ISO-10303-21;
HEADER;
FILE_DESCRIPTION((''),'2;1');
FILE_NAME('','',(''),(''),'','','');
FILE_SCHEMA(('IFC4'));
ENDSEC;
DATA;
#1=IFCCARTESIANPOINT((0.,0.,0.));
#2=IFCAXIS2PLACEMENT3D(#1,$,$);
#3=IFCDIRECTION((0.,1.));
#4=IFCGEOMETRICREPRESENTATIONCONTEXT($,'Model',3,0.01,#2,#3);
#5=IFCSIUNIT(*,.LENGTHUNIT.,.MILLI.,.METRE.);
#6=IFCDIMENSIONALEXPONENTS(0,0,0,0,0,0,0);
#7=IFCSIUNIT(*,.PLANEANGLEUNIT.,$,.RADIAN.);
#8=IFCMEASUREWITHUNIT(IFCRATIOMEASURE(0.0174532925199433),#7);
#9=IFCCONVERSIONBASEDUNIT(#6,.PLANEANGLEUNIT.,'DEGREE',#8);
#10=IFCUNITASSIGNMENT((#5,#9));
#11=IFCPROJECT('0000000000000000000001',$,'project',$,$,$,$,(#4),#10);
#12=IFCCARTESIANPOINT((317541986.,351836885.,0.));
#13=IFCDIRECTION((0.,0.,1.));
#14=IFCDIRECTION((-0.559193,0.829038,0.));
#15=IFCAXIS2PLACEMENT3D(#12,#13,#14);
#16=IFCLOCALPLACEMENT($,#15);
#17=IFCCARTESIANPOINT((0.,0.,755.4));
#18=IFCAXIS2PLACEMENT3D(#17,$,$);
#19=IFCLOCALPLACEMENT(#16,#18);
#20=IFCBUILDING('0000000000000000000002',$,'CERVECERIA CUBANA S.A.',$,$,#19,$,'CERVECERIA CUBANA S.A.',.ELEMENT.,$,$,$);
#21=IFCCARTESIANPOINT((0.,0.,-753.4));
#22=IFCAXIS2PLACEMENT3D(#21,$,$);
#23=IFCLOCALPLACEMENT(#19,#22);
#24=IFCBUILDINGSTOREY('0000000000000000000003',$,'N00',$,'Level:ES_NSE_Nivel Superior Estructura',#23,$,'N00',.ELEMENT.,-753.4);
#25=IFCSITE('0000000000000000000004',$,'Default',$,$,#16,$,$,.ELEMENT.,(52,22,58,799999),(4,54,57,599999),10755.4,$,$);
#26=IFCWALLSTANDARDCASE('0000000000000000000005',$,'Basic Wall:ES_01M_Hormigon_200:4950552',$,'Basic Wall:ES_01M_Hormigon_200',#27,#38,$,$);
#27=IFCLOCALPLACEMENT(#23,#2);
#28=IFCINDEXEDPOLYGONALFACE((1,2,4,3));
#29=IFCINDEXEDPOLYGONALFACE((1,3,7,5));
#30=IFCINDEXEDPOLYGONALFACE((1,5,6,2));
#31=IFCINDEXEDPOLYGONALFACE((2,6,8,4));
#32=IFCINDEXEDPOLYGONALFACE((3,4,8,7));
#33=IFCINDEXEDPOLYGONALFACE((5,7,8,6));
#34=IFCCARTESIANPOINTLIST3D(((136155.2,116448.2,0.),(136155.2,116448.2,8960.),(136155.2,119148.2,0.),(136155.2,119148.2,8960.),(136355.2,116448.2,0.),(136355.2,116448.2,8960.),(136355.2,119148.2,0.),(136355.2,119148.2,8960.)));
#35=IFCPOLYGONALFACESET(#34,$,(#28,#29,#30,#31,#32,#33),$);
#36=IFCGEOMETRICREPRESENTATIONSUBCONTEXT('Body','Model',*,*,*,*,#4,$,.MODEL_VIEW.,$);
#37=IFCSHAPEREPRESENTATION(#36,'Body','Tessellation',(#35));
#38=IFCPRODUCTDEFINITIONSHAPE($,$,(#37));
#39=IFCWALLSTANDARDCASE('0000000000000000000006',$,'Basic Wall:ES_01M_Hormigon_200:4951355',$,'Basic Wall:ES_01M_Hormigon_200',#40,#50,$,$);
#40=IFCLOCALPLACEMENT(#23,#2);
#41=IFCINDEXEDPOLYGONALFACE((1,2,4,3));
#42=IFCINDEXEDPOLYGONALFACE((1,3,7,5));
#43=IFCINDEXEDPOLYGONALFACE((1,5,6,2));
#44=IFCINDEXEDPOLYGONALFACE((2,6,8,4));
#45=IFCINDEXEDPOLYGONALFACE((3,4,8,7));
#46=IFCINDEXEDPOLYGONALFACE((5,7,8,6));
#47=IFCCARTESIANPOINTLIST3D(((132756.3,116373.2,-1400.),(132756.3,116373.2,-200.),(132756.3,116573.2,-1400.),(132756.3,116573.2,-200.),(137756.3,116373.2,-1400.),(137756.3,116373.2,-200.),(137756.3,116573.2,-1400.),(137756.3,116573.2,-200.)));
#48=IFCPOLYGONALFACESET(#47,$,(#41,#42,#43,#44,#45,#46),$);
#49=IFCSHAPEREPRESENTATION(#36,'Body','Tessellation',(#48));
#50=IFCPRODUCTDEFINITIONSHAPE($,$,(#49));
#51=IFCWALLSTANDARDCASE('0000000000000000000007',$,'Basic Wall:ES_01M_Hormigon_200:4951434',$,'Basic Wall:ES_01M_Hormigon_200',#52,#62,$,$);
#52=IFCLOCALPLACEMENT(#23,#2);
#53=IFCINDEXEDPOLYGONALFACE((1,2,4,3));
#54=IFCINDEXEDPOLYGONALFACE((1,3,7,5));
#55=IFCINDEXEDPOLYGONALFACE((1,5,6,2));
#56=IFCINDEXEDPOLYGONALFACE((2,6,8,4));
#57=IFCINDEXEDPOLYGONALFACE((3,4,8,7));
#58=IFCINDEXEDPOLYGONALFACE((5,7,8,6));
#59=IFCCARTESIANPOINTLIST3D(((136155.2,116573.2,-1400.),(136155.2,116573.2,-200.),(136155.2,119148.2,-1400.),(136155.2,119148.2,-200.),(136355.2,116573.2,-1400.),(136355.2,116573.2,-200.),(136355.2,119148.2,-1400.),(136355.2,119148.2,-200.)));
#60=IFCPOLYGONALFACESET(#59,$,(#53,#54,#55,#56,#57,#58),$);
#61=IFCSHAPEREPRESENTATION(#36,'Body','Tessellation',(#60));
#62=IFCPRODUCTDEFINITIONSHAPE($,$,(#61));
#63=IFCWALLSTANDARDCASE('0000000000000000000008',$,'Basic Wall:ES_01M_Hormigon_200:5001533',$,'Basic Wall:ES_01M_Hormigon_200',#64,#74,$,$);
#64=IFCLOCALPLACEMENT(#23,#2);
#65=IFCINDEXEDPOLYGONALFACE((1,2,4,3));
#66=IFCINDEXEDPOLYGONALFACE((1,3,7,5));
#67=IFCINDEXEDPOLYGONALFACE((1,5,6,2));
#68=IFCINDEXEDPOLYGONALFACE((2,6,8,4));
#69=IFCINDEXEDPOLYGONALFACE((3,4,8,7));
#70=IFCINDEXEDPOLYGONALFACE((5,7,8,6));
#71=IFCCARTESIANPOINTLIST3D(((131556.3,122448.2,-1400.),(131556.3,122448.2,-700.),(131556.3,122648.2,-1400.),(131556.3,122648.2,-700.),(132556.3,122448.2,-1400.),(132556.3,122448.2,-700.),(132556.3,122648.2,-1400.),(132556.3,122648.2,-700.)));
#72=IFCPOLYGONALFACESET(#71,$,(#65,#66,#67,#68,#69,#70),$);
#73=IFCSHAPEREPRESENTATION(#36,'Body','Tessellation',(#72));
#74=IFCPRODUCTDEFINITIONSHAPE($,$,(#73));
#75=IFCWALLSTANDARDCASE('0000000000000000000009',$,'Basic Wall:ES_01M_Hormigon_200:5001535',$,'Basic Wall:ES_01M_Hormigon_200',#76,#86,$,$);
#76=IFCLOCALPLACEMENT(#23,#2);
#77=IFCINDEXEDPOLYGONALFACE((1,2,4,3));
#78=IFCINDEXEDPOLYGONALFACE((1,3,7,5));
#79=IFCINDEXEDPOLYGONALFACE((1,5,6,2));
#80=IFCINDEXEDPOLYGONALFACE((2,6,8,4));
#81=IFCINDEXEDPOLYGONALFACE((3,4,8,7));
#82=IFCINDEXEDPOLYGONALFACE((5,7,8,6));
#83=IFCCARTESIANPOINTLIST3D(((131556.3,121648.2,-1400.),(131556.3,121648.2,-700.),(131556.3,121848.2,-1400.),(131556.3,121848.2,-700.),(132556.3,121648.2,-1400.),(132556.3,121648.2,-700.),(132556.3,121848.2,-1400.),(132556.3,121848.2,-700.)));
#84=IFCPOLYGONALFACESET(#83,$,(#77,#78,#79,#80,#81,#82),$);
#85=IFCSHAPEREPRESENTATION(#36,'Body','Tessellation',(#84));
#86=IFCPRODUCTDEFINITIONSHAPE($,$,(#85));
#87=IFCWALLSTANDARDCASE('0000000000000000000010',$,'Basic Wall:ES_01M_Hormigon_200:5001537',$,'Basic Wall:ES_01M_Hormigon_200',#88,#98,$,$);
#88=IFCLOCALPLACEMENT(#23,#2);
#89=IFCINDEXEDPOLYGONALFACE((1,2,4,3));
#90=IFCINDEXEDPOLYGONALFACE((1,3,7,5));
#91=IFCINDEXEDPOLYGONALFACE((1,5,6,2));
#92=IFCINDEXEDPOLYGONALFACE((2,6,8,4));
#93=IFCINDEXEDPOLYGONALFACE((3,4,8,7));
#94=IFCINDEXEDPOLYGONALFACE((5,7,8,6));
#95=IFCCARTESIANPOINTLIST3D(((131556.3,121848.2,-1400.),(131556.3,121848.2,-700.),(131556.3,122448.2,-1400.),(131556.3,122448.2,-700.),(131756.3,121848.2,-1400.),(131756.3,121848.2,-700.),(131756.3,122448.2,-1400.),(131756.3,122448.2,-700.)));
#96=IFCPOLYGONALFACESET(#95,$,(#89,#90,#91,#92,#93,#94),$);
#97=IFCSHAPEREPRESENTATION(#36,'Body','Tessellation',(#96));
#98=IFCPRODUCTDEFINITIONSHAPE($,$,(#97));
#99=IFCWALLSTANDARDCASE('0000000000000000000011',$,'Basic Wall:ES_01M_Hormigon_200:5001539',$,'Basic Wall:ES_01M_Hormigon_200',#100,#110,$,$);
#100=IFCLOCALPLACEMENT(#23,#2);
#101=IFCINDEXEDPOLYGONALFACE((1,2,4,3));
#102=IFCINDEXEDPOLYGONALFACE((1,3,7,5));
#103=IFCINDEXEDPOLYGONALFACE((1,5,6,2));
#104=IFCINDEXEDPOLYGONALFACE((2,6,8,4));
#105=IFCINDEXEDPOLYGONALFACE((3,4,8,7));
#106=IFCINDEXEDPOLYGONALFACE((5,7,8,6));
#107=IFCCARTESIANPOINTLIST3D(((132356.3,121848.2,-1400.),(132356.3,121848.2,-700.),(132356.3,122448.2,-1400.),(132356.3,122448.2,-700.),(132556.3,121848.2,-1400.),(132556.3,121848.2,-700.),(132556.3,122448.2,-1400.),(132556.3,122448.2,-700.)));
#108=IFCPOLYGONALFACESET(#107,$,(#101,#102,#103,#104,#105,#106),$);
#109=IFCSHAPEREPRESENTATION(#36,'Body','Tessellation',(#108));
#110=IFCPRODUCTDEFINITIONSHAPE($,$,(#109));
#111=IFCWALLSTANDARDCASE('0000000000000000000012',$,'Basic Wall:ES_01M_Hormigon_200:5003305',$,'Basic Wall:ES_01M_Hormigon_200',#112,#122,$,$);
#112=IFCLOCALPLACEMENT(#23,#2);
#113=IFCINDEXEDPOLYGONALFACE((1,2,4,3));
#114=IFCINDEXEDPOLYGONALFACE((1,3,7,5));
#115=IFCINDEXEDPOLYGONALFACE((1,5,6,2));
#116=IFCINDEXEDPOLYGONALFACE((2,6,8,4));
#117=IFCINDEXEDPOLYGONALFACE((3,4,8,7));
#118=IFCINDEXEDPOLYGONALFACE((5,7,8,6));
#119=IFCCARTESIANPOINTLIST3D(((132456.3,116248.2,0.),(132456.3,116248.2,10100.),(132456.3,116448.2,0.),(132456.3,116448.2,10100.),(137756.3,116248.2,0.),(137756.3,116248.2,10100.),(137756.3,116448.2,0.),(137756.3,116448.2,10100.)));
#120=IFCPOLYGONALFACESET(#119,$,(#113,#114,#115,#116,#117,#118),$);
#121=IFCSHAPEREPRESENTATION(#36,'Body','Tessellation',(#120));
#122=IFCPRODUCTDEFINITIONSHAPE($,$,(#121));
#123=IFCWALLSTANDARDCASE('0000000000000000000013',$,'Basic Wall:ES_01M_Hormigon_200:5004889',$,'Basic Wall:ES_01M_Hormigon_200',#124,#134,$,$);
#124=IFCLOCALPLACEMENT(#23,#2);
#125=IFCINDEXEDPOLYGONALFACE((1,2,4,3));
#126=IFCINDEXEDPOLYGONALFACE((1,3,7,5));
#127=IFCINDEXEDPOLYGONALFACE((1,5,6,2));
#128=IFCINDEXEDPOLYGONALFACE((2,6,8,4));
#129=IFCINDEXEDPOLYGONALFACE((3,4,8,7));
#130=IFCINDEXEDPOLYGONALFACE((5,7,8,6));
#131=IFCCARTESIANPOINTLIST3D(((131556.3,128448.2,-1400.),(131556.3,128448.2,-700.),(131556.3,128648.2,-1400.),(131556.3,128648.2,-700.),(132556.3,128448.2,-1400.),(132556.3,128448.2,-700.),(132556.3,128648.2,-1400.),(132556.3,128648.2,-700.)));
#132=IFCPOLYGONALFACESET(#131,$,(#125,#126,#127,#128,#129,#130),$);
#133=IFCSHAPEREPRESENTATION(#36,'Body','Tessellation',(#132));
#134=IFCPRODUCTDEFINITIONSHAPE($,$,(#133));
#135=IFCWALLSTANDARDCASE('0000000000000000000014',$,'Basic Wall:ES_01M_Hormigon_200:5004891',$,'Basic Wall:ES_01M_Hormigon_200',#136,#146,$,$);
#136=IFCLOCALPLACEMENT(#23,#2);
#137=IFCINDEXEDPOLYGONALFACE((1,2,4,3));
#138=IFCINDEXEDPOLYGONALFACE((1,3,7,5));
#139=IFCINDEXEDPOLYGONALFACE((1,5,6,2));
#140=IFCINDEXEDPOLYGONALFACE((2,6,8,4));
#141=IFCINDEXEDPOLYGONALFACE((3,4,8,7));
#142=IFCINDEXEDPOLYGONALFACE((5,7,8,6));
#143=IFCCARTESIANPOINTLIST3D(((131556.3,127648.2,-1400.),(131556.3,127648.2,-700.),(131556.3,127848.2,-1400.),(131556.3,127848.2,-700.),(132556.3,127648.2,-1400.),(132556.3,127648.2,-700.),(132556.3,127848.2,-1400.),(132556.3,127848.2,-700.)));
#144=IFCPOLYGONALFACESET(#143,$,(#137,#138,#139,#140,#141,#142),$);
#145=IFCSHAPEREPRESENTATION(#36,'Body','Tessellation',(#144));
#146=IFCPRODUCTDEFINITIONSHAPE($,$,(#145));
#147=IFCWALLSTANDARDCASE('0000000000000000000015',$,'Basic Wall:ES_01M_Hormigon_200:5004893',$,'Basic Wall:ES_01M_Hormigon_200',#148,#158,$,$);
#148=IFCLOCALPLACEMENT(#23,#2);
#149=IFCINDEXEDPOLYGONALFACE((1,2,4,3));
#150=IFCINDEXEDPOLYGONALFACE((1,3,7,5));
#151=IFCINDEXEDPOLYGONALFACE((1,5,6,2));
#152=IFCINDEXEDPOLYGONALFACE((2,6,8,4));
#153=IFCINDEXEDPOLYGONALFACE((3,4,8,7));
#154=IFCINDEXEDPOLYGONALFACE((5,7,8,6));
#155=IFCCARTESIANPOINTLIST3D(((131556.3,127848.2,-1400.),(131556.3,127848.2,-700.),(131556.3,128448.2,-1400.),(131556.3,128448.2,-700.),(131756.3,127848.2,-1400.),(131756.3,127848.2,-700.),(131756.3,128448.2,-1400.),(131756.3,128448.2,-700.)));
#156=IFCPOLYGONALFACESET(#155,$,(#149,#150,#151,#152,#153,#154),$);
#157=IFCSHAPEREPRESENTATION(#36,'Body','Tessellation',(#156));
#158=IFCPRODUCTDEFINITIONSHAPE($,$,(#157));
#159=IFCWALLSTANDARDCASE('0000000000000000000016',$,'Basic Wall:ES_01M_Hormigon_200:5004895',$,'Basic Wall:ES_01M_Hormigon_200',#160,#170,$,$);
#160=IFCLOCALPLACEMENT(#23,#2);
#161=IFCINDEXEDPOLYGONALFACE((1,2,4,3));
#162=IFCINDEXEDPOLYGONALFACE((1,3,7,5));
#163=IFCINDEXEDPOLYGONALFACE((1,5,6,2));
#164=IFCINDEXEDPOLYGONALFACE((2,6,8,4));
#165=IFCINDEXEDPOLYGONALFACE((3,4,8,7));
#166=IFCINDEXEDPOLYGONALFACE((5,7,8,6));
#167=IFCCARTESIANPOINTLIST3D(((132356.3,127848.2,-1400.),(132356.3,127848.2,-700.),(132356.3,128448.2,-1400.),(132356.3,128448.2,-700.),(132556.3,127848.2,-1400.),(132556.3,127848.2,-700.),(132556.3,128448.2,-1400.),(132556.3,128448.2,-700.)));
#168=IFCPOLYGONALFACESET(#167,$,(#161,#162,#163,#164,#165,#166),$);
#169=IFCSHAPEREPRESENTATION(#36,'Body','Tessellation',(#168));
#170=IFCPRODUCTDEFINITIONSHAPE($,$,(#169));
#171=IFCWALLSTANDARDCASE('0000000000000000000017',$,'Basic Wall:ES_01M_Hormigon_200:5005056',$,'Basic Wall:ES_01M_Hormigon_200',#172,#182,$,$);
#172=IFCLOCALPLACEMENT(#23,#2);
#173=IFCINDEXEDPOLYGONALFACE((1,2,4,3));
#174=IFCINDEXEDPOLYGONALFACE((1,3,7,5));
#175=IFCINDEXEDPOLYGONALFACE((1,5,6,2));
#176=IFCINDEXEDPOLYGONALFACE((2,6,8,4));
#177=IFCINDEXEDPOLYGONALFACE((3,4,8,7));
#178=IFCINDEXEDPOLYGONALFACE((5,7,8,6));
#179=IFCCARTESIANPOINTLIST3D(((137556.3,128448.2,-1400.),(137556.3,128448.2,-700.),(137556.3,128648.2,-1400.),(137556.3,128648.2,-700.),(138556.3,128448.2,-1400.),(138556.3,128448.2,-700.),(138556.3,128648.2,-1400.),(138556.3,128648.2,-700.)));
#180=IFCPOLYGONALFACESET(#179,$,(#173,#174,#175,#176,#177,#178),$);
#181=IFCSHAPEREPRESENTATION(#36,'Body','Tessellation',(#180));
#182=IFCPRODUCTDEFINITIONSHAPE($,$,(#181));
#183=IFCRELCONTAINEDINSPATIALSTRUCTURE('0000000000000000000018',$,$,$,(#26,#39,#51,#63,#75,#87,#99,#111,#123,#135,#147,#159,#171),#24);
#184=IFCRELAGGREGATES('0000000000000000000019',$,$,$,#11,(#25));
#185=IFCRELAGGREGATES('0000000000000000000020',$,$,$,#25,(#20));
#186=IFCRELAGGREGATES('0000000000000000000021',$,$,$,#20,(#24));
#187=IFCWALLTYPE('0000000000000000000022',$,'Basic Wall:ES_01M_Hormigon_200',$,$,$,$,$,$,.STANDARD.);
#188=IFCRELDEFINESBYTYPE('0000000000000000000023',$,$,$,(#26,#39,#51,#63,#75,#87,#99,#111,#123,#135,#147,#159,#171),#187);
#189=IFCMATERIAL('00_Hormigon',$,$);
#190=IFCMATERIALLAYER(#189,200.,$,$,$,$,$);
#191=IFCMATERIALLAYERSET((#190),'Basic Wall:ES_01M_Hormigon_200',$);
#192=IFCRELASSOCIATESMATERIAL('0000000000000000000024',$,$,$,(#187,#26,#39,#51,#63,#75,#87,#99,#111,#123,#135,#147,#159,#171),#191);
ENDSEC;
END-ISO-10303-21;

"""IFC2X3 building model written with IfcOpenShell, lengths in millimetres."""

from ifc_helpers import new_model, entity, si_unit, converted_unit, direction, frame, frame_2d, origin, place, context, subcontext, project, spatial, polyline, rectangle, extrude, clip, bounded_halfspace, material, layer, layer_set, layer_usage, type_object, element, save


model = new_model("IFC2X3")

# Units and contexts
model_context = context("Model", 3, precision=0.01, world=origin(), true_north=direction((0.0, 1.0)))
body_context = subcontext(model_context, "Body", "Model", "MODEL_VIEW")
ifc_project = project(units=[si_unit("LENGTHUNIT", "METRE", prefix="MILLI"), converted_unit("PLANEANGLEUNIT", "DEGREE", entity("IfcRatioMeasure", 0.0174532925199433), si_unit("PLANEANGLEUNIT", "RADIAN"), dimensions=[0, 0, 0, 0, 0, 0, 0])], contexts=[model_context])

# Site, building, storey
site_placement = place(None, frame((317541986.0, 351836885.0, 0.0), z_axis=(0.0, 0.0, 1.0), x_axis=(-0.559193, 0.829038, 0.0)))
site = spatial("IfcSite", under=ifc_project, at=site_placement, Name="Default", CompositionType="ELEMENT", RefLatitude=(52, 22, 58, 799999), RefLongitude=(4, 54, 57, 599999), RefElevation=10755.4)
building_placement = place(site_placement, frame((0.0, 0.0, 755.4)))
building = spatial("IfcBuilding", under=site, at=building_placement, Name="CERVECERIA CUBANA S.A.", LongName="CERVECERIA CUBANA S.A.", CompositionType="ELEMENT")
storey_placement = place(building_placement, frame((0.0, 0.0, -753.4)))
storey = spatial("IfcBuildingStorey", under=building, at=storey_placement, Name="N00", ObjectType="Level:ES_NSE_Nivel Superior Estructura", LongName="N00", CompositionType="ELEMENT", Elevation=-753.4)

# Walls
ifc_material = material(Name="00_Hormigon")
ifc_layer = layer(ifc_material, 200.0)
ifc_layer_set = layer_set([ifc_layer], Name="Basic Wall:ES_01M_Hormigon_200")
ifc_layer_usage_1 = layer_usage(ifc_layer_set, "AXIS2", "NEGATIVE", 100.0)
wall_type = type_object("IfcWallType", Name="Basic Wall:ES_01M_Hormigon_200", PredefinedType="STANDARD", material=ifc_layer_set)
wall_1_placement = place(storey_placement, frame((136255.2, 119148.2, 0.0), z_axis=(0.0, 0.0, 1.0), x_axis=(0.0, -1.0, 0.0)))
element("IfcWallStandardCase", 1, at=wall_1_placement, inside=storey, type_object=wall_type, material=ifc_layer_usage_1, Name="Basic Wall:ES_01M_Hormigon_200:4950552", ObjectType="Basic Wall:ES_01M_Hormigon_200", context=body_context, shape_type="SweptSolid", body=[
    extrude(rectangle(XDim=2700.0, YDim=200.0, at=frame_2d((1350.0, 0.0), x_axis=(-1.0, 0.0))), origin(), (0.0, 0.0, 1.0), 8960.0),
])
ifc_layer_usage_2 = layer_usage(ifc_layer_set, "AXIS2", "POSITIVE", -100.0)
wall_2_placement = place(storey_placement, frame((132756.3, 116473.2, -1400.0)))
element("IfcWallStandardCase", 2, at=wall_2_placement, inside=storey, type_object=wall_type, material=ifc_layer_usage_2, Name="Basic Wall:ES_01M_Hormigon_200:4951355", ObjectType="Basic Wall:ES_01M_Hormigon_200", context=body_context, shape_type="Clipping", body=[
    clip(extrude(rectangle(XDim=5000.0, YDim=200.0, at=frame_2d((2500.0, 0.0), x_axis=(-1.0, 0.0))), origin(), (0.0, 0.0, 1.0), 1200.0), bounded_halfspace(frame((0.0, -100.0, 1200.0), z_axis=(0.0, 0.0, -1.0), x_axis=(0.0, 1.0, 0.0)), True, frame((0.0, -100.0, 1200.0), z_axis=(0.0, 0.0, -1.0), x_axis=(0.0, 1.0, 0.0)), polyline([(0.0, 0.0), (200.0, 0.0), (200.0, 3398.8), (200.0, 3598.8), (200.0, 5000.0), (75.0, 5000.0), (0.0, 5000.0), (0.0, 0.0)]))),
])
ifc_layer_usage_3 = layer_usage(ifc_layer_set, "AXIS2", "NEGATIVE", 100.0)
wall_3_placement = place(storey_placement, frame((136255.2, 119148.2, -1400.0), z_axis=(0.0, 0.0, 1.0), x_axis=(0.0, -1.0, 0.0)))
element("IfcWallStandardCase", 3, at=wall_3_placement, inside=storey, type_object=wall_type, material=ifc_layer_usage_3, Name="Basic Wall:ES_01M_Hormigon_200:4951434", ObjectType="Basic Wall:ES_01M_Hormigon_200", context=body_context, shape_type="Clipping", body=[
    clip(extrude(rectangle(XDim=2575.0, YDim=200.0, at=frame_2d((1287.5, 0.0), x_axis=(-1.0, 0.0))), origin(), (0.0, 0.0, 1.0), 1200.0), bounded_halfspace(frame((0.0, -100.0, 1200.0), z_axis=(0.0, 0.0, -1.0), x_axis=(-1.0, 0.0, 0.0)), True, frame((0.0, -100.0, 1200.0), z_axis=(0.0, 0.0, -1.0), x_axis=(-1.0, 0.0, 0.0)), polyline([(0.0, 0.0), (0.0, 200.0), (-2575.0, 200.0), (-2575.0, 0.0), (0.0, 0.0)]))),
])
ifc_layer_usage_4 = layer_usage(ifc_layer_set, "AXIS2", "NEGATIVE", 100.0)
wall_4_placement = place(storey_placement, frame((131556.3, 122548.2, -1400.0)))
element("IfcWallStandardCase", 4, at=wall_4_placement, inside=storey, type_object=wall_type, material=ifc_layer_usage_4, Name="Basic Wall:ES_01M_Hormigon_200:5001533", ObjectType="Basic Wall:ES_01M_Hormigon_200", context=body_context, shape_type="SweptSolid", body=[
    extrude(rectangle(XDim=1000.0, YDim=200.0, at=frame_2d((500.0, 0.0), x_axis=(-1.0, 0.0))), origin(), (0.0, 0.0, 1.0), 700.0),
])
ifc_layer_usage_5 = layer_usage(ifc_layer_set, "AXIS2", "POSITIVE", -100.0)
wall_5_placement = place(storey_placement, frame((131556.3, 121748.2, -1400.0)))
element("IfcWallStandardCase", 5, at=wall_5_placement, inside=storey, type_object=wall_type, material=ifc_layer_usage_5, Name="Basic Wall:ES_01M_Hormigon_200:5001535", ObjectType="Basic Wall:ES_01M_Hormigon_200", context=body_context, shape_type="SweptSolid", body=[
    extrude(rectangle(XDim=1000.0, YDim=200.0, at=frame_2d((500.0, 0.0), x_axis=(-1.0, 0.0))), origin(), (0.0, 0.0, 1.0), 700.0),
])
ifc_layer_usage_6 = layer_usage(ifc_layer_set, "AXIS2", "POSITIVE", -100.0)
wall_6_placement = place(storey_placement, frame((131656.3, 122448.2, -1400.0), z_axis=(0.0, 0.0, 1.0), x_axis=(0.0, -1.0, 0.0)))
element("IfcWallStandardCase", 6, at=wall_6_placement, inside=storey, type_object=wall_type, material=ifc_layer_usage_6, Name="Basic Wall:ES_01M_Hormigon_200:5001537", ObjectType="Basic Wall:ES_01M_Hormigon_200", context=body_context, shape_type="SweptSolid", body=[
    extrude(rectangle(XDim=600.0, YDim=200.0, at=frame_2d((300.0, 0.0), x_axis=(-1.0, 0.0))), origin(), (0.0, 0.0, 1.0), 700.0),
])
ifc_layer_usage_7 = layer_usage(ifc_layer_set, "AXIS2", "NEGATIVE", 100.0)
wall_7_placement = place(storey_placement, frame((132456.3, 122448.2, -1400.0), z_axis=(0.0, 0.0, 1.0), x_axis=(0.0, -1.0, 0.0)))
element("IfcWallStandardCase", 7, at=wall_7_placement, inside=storey, type_object=wall_type, material=ifc_layer_usage_7, Name="Basic Wall:ES_01M_Hormigon_200:5001539", ObjectType="Basic Wall:ES_01M_Hormigon_200", context=body_context, shape_type="SweptSolid", body=[
    extrude(rectangle(XDim=600.0, YDim=200.0, at=frame_2d((300.0, 0.0), x_axis=(-1.0, 0.0))), origin(), (0.0, 0.0, 1.0), 700.0),
])
ifc_layer_usage_8 = layer_usage(ifc_layer_set, "AXIS2", "POSITIVE", -100.0)
wall_8_placement = place(storey_placement, frame((132456.3, 116348.2, 0.0)))
element("IfcWallStandardCase", 8, at=wall_8_placement, inside=storey, type_object=wall_type, material=ifc_layer_usage_8, Name="Basic Wall:ES_01M_Hormigon_200:5003305", ObjectType="Basic Wall:ES_01M_Hormigon_200", context=body_context, shape_type="SweptSolid", body=[
    extrude(rectangle(XDim=5300.0, YDim=200.0, at=frame_2d((2650.0, 0.0), x_axis=(-1.0, 0.0))), origin(), (0.0, 0.0, 1.0), 10100.0),
])
ifc_layer_usage_9 = layer_usage(ifc_layer_set, "AXIS2", "NEGATIVE", 100.0)
wall_9_placement = place(storey_placement, frame((131556.3, 128548.2, -1400.0)))
element("IfcWallStandardCase", 9, at=wall_9_placement, inside=storey, type_object=wall_type, material=ifc_layer_usage_9, Name="Basic Wall:ES_01M_Hormigon_200:5004889", ObjectType="Basic Wall:ES_01M_Hormigon_200", context=body_context, shape_type="SweptSolid", body=[
    extrude(rectangle(XDim=1000.0, YDim=200.0, at=frame_2d((500.0, 0.0), x_axis=(-1.0, 0.0))), origin(), (0.0, 0.0, 1.0), 700.0),
])
ifc_layer_usage_10 = layer_usage(ifc_layer_set, "AXIS2", "POSITIVE", -100.0)
wall_10_placement = place(storey_placement, frame((131556.3, 127748.2, -1400.0)))
element("IfcWallStandardCase", 10, at=wall_10_placement, inside=storey, type_object=wall_type, material=ifc_layer_usage_10, Name="Basic Wall:ES_01M_Hormigon_200:5004891", ObjectType="Basic Wall:ES_01M_Hormigon_200", context=body_context, shape_type="SweptSolid", body=[
    extrude(rectangle(XDim=1000.0, YDim=200.0, at=frame_2d((500.0, 0.0), x_axis=(-1.0, 0.0))), origin(), (0.0, 0.0, 1.0), 700.0),
])
ifc_layer_usage_11 = layer_usage(ifc_layer_set, "AXIS2", "POSITIVE", -100.0)
wall_11_placement = place(storey_placement, frame((131656.3, 128448.2, -1400.0), z_axis=(0.0, 0.0, 1.0), x_axis=(0.0, -1.0, 0.0)))
element("IfcWallStandardCase", 11, at=wall_11_placement, inside=storey, type_object=wall_type, material=ifc_layer_usage_11, Name="Basic Wall:ES_01M_Hormigon_200:5004893", ObjectType="Basic Wall:ES_01M_Hormigon_200", context=body_context, shape_type="SweptSolid", body=[
    extrude(rectangle(XDim=600.0, YDim=200.0, at=frame_2d((300.0, 0.0), x_axis=(-1.0, 0.0))), origin(), (0.0, 0.0, 1.0), 700.0),
])
ifc_layer_usage_12 = layer_usage(ifc_layer_set, "AXIS2", "NEGATIVE", 100.0)
wall_12_placement = place(storey_placement, frame((132456.3, 128448.2, -1400.0), z_axis=(0.0, 0.0, 1.0), x_axis=(0.0, -1.0, 0.0)))
element("IfcWallStandardCase", 12, at=wall_12_placement, inside=storey, type_object=wall_type, material=ifc_layer_usage_12, Name="Basic Wall:ES_01M_Hormigon_200:5004895", ObjectType="Basic Wall:ES_01M_Hormigon_200", context=body_context, shape_type="SweptSolid", body=[
    extrude(rectangle(XDim=600.0, YDim=200.0, at=frame_2d((300.0, 0.0), x_axis=(-1.0, 0.0))), origin(), (0.0, 0.0, 1.0), 700.0),
])
ifc_layer_usage_13 = layer_usage(ifc_layer_set, "AXIS2", "NEGATIVE", 100.0)
wall_13_placement = place(storey_placement, frame((137556.3, 128548.2, -1400.0)))
element("IfcWallStandardCase", 13, at=wall_13_placement, inside=storey, type_object=wall_type, material=ifc_layer_usage_13, Name="Basic Wall:ES_01M_Hormigon_200:5005056", ObjectType="Basic Wall:ES_01M_Hormigon_200", context=body_context, shape_type="SweptSolid", body=[
    extrude(rectangle(XDim=1000.0, YDim=200.0, at=frame_2d((500.0, 0.0), x_axis=(-1.0, 0.0))), origin(), (0.0, 0.0, 1.0), 700.0),
])

save(model, "model.ifc")
